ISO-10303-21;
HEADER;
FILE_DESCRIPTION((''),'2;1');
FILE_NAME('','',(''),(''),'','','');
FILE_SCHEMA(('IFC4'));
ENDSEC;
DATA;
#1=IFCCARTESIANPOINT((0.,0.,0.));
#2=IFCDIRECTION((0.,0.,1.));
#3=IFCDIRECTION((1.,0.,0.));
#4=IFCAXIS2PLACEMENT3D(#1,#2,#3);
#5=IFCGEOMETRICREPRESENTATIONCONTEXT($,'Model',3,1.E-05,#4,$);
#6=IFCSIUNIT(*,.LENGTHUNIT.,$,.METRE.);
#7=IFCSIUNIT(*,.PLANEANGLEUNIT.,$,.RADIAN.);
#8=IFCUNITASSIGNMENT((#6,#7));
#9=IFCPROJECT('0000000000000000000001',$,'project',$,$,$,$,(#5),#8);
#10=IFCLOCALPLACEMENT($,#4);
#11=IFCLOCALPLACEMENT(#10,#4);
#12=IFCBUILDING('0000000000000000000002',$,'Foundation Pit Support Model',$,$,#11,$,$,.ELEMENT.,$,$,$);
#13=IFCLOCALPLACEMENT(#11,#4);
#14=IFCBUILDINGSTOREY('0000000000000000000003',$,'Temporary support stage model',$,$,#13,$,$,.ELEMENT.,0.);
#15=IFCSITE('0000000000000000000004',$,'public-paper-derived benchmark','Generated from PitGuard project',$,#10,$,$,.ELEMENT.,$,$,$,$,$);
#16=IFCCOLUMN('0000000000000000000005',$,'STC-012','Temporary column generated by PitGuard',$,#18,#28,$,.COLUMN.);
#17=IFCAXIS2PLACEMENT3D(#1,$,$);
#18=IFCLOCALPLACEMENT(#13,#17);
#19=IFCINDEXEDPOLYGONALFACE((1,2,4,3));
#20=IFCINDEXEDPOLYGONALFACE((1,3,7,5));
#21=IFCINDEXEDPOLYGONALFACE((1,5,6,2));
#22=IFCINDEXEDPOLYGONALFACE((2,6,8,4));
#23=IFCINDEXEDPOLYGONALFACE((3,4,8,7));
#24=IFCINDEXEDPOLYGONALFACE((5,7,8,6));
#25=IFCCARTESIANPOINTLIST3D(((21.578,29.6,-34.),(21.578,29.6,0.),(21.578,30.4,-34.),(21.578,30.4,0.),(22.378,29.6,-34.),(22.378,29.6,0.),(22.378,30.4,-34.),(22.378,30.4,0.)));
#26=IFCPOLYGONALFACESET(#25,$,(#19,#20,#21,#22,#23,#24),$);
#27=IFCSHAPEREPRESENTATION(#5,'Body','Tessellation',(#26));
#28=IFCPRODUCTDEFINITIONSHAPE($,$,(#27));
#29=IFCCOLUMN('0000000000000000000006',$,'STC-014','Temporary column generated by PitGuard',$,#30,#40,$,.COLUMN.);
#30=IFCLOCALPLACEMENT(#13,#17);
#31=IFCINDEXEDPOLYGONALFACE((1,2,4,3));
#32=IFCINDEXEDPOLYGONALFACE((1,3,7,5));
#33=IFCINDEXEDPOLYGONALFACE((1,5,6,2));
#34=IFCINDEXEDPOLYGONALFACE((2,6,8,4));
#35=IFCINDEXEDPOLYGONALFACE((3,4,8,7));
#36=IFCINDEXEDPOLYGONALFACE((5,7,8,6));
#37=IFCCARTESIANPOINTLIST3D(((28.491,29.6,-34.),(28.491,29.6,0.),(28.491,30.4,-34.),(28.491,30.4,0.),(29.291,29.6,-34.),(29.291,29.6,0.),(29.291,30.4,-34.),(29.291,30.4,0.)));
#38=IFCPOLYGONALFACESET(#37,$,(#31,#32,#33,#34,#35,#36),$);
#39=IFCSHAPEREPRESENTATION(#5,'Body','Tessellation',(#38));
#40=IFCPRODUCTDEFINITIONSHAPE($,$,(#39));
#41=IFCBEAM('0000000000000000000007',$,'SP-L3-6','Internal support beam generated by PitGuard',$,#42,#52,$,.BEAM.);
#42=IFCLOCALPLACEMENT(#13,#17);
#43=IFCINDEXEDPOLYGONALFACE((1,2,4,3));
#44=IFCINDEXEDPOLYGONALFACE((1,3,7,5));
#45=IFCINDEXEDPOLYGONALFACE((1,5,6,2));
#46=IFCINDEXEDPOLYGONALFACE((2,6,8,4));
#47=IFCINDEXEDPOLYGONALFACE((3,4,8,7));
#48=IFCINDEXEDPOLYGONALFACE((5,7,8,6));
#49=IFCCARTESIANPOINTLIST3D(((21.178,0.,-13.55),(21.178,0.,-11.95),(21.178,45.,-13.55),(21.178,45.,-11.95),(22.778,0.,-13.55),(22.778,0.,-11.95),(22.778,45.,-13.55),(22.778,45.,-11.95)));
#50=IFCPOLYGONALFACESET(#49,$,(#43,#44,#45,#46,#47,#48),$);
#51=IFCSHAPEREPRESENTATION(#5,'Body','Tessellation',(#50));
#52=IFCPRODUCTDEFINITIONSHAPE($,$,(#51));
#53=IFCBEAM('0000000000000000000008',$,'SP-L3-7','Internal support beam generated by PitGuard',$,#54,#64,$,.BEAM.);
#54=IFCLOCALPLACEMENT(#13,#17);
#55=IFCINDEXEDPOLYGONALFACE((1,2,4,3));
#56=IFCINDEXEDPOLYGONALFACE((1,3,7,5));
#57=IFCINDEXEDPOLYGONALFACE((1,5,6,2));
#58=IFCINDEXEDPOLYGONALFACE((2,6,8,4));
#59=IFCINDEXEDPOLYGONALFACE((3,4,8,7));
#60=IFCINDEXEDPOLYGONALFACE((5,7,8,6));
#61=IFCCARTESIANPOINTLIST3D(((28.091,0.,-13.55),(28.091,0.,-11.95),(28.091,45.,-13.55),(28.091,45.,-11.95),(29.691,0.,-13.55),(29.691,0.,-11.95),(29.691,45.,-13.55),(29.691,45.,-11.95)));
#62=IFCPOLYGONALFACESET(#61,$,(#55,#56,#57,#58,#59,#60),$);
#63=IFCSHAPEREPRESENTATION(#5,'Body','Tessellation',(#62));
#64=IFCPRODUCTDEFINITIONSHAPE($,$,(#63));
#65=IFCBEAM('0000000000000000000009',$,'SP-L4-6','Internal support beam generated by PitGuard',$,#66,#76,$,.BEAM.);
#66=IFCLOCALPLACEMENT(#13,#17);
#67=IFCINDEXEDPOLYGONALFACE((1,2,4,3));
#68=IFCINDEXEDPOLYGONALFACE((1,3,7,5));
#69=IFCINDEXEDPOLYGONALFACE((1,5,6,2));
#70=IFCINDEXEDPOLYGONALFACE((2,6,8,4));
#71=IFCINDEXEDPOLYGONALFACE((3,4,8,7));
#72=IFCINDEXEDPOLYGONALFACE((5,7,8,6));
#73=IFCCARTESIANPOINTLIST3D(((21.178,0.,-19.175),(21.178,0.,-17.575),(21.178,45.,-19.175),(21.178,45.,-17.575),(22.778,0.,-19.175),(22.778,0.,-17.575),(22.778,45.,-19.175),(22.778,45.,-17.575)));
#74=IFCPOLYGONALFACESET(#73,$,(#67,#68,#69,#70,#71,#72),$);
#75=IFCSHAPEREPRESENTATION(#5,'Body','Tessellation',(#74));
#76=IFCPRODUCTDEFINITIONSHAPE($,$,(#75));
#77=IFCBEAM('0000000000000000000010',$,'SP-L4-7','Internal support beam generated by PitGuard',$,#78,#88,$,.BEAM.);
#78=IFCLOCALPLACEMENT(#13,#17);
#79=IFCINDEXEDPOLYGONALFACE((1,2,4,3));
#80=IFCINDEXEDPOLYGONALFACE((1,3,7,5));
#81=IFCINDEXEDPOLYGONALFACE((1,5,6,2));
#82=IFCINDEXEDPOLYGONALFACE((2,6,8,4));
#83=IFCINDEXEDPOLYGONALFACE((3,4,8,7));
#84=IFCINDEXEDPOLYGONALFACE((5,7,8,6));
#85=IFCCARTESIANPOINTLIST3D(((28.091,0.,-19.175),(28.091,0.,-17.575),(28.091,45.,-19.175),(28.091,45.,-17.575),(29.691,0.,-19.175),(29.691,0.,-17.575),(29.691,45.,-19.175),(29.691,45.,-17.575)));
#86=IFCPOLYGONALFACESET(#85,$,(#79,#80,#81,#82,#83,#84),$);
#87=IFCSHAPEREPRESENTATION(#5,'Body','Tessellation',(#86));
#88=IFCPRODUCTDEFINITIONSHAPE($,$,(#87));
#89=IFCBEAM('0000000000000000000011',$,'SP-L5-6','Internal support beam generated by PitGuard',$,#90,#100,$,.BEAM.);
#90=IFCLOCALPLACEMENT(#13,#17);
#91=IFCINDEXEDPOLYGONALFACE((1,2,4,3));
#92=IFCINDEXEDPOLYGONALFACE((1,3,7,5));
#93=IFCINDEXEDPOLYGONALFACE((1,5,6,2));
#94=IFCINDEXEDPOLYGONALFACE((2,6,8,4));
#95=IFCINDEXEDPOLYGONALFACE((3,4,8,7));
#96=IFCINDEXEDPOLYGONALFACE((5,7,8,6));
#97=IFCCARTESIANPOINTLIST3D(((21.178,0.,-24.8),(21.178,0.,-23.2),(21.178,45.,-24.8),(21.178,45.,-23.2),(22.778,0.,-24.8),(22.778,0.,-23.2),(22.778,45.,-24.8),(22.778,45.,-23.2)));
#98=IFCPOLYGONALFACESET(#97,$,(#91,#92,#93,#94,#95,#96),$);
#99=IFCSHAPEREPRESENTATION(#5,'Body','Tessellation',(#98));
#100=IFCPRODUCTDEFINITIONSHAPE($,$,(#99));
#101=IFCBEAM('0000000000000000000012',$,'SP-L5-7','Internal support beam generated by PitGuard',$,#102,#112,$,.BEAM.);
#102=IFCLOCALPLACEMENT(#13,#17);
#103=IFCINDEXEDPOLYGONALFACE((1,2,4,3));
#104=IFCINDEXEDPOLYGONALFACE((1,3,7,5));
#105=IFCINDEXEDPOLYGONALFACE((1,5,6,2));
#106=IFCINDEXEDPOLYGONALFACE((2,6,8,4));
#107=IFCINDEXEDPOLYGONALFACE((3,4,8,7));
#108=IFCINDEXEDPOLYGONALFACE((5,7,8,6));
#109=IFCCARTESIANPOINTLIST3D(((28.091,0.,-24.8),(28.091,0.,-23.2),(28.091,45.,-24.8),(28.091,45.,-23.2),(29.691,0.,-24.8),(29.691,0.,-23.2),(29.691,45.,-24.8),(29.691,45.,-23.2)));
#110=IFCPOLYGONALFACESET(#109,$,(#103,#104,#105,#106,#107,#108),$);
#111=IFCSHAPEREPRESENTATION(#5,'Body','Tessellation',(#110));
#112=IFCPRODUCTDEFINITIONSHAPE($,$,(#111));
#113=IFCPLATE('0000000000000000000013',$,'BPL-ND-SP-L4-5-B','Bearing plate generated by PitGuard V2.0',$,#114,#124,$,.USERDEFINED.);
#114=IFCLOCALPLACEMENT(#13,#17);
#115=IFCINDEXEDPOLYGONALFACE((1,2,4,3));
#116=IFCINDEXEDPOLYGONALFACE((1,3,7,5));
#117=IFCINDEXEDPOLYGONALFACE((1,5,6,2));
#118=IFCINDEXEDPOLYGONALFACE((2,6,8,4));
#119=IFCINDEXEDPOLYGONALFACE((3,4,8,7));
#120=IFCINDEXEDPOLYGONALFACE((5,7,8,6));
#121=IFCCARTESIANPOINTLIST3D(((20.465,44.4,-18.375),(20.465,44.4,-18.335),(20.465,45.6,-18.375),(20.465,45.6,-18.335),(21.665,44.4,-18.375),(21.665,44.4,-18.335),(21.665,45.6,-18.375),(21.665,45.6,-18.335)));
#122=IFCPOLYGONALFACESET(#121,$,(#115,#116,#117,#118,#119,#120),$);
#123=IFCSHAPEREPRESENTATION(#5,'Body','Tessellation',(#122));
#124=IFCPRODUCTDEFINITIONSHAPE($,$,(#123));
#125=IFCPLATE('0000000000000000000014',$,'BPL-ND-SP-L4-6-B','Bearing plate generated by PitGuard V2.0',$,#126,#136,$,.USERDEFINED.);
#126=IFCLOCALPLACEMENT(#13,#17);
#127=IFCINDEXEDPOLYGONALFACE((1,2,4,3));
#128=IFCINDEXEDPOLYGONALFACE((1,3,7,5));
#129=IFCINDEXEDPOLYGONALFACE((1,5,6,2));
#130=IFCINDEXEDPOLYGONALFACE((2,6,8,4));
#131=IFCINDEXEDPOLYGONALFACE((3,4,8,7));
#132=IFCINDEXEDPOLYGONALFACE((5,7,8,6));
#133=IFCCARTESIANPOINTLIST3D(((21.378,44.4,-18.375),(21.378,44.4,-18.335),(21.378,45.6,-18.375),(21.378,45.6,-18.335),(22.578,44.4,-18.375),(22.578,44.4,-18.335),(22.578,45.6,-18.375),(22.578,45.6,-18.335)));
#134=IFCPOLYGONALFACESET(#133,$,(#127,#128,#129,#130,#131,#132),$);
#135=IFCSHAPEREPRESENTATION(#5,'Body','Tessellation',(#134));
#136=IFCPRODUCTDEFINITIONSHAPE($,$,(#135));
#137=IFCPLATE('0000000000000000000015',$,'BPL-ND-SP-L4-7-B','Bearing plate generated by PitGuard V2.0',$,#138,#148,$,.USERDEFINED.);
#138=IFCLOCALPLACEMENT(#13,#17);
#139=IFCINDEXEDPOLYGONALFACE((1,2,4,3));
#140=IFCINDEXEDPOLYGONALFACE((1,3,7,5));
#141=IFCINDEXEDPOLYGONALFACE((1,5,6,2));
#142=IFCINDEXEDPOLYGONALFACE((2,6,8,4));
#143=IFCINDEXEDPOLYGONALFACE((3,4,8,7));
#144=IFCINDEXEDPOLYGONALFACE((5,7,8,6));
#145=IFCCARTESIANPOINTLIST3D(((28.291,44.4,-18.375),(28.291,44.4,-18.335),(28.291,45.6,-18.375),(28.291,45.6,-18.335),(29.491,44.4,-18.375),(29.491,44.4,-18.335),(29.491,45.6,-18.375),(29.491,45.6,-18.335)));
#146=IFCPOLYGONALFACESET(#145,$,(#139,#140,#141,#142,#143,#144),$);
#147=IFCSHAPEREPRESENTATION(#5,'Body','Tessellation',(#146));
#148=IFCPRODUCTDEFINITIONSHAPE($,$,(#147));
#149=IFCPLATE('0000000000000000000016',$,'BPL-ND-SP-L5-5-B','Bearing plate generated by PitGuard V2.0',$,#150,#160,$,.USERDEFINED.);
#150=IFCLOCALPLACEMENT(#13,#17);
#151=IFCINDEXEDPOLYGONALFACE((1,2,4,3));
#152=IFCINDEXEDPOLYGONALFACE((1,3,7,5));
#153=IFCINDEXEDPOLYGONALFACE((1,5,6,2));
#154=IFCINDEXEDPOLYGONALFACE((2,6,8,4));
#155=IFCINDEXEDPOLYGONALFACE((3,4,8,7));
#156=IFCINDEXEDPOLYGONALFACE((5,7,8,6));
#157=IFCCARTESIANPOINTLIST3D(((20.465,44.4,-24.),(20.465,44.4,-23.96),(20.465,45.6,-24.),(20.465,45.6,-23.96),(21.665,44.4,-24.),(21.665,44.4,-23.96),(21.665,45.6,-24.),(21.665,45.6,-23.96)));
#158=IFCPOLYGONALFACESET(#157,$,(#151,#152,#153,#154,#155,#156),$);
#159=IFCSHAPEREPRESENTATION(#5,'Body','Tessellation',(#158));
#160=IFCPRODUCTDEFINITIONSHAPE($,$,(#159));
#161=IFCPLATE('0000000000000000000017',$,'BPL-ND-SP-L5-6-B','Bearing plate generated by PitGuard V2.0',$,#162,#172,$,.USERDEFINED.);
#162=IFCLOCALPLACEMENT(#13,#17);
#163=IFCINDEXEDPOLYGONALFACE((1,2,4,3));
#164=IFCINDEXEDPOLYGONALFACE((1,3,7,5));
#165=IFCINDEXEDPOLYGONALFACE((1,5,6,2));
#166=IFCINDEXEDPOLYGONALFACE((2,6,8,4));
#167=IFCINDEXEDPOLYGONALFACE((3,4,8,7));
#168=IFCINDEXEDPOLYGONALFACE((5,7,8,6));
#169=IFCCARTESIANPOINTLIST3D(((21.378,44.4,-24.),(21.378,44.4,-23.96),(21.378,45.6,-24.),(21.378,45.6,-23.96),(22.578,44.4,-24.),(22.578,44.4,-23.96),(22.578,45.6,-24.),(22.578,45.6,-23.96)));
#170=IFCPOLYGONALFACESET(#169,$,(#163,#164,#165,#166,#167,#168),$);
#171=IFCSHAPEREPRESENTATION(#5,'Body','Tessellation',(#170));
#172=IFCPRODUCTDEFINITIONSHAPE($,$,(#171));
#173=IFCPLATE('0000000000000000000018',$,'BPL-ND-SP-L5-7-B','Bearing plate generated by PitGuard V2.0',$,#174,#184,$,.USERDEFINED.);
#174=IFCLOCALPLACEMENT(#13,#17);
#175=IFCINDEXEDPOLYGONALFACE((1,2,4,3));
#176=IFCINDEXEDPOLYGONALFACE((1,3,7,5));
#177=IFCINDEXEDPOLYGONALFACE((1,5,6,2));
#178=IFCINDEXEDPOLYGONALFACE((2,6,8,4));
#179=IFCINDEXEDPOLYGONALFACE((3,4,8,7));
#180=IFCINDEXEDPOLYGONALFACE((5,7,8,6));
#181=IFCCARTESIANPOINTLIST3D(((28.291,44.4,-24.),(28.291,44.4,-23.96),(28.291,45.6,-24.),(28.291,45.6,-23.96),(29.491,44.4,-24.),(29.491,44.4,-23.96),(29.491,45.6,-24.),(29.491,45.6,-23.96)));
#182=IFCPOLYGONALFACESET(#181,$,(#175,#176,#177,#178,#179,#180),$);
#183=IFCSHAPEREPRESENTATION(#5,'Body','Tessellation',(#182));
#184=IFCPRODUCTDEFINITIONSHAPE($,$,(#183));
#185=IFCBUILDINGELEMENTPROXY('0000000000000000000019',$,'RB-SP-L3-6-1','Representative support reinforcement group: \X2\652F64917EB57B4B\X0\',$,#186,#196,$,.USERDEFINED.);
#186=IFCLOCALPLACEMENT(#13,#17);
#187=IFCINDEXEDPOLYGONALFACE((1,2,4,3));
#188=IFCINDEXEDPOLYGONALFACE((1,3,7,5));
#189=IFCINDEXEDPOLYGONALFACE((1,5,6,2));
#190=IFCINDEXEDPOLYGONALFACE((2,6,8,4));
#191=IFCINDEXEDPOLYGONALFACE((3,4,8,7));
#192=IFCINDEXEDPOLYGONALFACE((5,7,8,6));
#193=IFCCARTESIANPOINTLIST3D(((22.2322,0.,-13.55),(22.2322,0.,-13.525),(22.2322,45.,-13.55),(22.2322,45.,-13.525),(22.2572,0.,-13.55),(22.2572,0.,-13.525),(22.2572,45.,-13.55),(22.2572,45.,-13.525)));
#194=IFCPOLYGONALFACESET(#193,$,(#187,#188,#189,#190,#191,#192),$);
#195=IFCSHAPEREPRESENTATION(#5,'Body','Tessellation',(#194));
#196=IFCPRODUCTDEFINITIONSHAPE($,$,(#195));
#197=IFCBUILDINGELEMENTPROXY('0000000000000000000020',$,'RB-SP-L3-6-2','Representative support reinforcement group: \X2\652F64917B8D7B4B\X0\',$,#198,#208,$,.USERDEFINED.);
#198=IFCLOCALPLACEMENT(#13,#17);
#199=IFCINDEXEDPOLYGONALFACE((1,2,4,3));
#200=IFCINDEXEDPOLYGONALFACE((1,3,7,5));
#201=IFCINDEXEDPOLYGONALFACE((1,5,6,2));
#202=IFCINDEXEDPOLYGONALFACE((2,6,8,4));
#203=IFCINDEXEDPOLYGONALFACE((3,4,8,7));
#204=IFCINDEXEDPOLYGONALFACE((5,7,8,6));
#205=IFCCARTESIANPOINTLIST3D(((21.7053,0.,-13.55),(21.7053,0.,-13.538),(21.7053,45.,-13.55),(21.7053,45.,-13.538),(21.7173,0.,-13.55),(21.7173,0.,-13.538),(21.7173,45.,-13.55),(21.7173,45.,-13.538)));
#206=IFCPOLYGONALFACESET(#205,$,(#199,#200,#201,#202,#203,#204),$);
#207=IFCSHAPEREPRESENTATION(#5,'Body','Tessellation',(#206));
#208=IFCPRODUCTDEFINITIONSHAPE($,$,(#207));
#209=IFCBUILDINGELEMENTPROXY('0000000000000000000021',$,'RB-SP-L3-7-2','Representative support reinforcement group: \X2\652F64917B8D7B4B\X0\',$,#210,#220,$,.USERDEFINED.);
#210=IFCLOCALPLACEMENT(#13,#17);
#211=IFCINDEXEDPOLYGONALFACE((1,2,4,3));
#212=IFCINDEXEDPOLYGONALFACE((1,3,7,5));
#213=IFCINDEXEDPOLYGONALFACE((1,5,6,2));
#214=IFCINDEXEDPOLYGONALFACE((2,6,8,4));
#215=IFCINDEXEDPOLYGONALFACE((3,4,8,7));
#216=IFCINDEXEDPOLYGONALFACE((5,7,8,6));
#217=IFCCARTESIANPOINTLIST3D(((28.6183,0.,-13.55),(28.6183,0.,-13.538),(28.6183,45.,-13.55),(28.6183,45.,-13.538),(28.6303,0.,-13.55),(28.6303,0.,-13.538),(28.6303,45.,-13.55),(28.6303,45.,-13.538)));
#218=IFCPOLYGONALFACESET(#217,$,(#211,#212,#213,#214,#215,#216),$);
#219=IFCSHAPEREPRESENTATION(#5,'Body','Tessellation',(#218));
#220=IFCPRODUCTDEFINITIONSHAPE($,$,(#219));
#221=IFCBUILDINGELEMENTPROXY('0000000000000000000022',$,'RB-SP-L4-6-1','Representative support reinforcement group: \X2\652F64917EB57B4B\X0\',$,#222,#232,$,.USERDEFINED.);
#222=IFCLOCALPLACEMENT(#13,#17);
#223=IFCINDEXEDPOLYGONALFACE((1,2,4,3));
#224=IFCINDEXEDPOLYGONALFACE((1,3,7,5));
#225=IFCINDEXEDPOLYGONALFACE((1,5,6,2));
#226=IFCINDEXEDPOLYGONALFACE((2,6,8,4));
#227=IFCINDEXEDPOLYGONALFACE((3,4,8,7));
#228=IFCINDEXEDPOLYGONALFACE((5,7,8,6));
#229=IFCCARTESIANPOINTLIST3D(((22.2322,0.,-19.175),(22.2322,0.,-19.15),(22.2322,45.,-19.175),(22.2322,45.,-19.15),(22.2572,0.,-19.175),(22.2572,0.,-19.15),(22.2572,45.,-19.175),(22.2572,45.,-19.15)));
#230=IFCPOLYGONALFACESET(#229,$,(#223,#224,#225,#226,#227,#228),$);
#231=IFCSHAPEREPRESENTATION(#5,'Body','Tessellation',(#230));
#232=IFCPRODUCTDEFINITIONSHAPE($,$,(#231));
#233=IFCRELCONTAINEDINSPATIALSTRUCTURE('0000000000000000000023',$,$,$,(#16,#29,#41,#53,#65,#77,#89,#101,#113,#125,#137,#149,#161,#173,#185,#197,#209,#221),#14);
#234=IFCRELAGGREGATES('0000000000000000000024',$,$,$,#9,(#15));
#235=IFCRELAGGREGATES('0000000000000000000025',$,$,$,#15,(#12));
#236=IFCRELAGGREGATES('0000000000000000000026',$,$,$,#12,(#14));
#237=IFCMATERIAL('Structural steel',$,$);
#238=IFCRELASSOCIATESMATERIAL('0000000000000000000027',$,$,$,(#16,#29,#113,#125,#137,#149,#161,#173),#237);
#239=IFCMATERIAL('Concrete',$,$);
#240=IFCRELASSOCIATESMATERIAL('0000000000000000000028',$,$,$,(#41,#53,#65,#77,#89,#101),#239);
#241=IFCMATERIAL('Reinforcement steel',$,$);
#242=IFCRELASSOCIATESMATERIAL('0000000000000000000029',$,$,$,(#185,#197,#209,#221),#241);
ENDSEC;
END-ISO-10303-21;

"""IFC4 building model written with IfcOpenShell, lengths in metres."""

from ifc_helpers import new_model, si_unit, frame, origin_with_axes, origin_2d, place, context, project, spatial, rectangle, extrude, material, element, save


model = new_model("IFC4")

# Units and contexts
model_context = context("Model", 3, precision=1e-05, world=origin_with_axes())
ifc_project = project(units=[si_unit("LENGTHUNIT", "METRE"), si_unit("PLANEANGLEUNIT", "RADIAN")], contexts=[model_context])

# Site, building, storey
site_placement = place(None, origin_with_axes())
site = spatial("IfcSite", under=ifc_project, at=site_placement, Name="public-paper-derived benchmark", Description="Generated from PitGuard project", CompositionType="ELEMENT")
building_placement = place(site_placement, origin_with_axes())
building = spatial("IfcBuilding", under=site, at=building_placement, Name="Foundation Pit Support Model", CompositionType="ELEMENT")
storey_placement = place(building_placement, origin_with_axes())
storey = spatial("IfcBuildingStorey", under=building, at=storey_placement, Name="Temporary support stage model", CompositionType="ELEMENT", Elevation=0.0)

# Columns
ifc_material_1 = material(Name="Structural steel")
for number, where, z_axis, x_axis, name in (
    (1, (21.978, 30.0, -34.0), (0.0, 0.0, 1.0), (1.0, 0.0, 0.0), "STC-012"),
    (2, (28.891, 30.0, -34.0), (0.0, 0.0, 1.0), (1.0, 0.0, 0.0), "STC-014"),
):
    element("IfcColumn", number, at=place(storey_placement, frame(where, z_axis=z_axis, x_axis=x_axis)), inside=storey, material=ifc_material_1, Name=name, Description="Temporary column generated by PitGuard", PredefinedType="COLUMN", context=model_context, shape_type="SweptSolid", body=[
        extrude(rectangle(XDim=0.8, YDim=0.8, at=origin_2d()), origin_with_axes(), (0.0, 0.0, 1.0), 34.0),
    ])

# Beams
ifc_material_2 = material(Name="Concrete")
for number, where, z_axis, x_axis, name in (
    (3, (21.978, 22.5, -13.55), (0.0, 0.0, 1.0), (0.0, 1.0, 0.0), "SP-L3-6"),
    (4, (28.891, 22.5, -13.55), (0.0, 0.0, 1.0), (0.0, 1.0, 0.0), "SP-L3-7"),
    (5, (21.978, 22.5, -19.175), (0.0, 0.0, 1.0), (0.0, 1.0, 0.0), "SP-L4-6"),
    (6, (28.891, 22.5, -19.175), (0.0, 0.0, 1.0), (0.0, 1.0, 0.0), "SP-L4-7"),
    (7, (21.978, 22.5, -24.8), (0.0, 0.0, 1.0), (0.0, 1.0, 0.0), "SP-L5-6"),
    (8, (28.891, 22.5, -24.8), (0.0, 0.0, 1.0), (0.0, 1.0, 0.0), "SP-L5-7"),
):
    element("IfcBeam", number, at=place(storey_placement, frame(where, z_axis=z_axis, x_axis=x_axis)), inside=storey, material=ifc_material_2, Name=name, Description="Internal support beam generated by PitGuard", PredefinedType="BEAM", context=model_context, shape_type="SweptSolid", body=[
        extrude(rectangle(XDim=45.0, YDim=1.6, at=origin_2d()), origin_with_axes(), (0.0, 0.0, 1.0), 1.6),
    ])

# Plates
for number, where, z_axis, x_axis, name in (
    (9, (21.065, 45.0, -18.375), (0.0, 0.0, 1.0), (1.0, 0.0, 0.0), "BPL-ND-SP-L4-5-B"),
    (10, (21.978, 45.0, -18.375), (0.0, 0.0, 1.0), (1.0, 0.0, 0.0), "BPL-ND-SP-L4-6-B"),
    (11, (28.891, 45.0, -18.375), (0.0, 0.0, 1.0), (1.0, 0.0, 0.0), "BPL-ND-SP-L4-7-B"),
    (12, (21.065, 45.0, -24.0), (0.0, 0.0, 1.0), (1.0, 0.0, 0.0), "BPL-ND-SP-L5-5-B"),
    (13, (21.978, 45.0, -24.0), (0.0, 0.0, 1.0), (1.0, 0.0, 0.0), "BPL-ND-SP-L5-6-B"),
    (14, (28.891, 45.0, -24.0), (0.0, 0.0, 1.0), (1.0, 0.0, 0.0), "BPL-ND-SP-L5-7-B"),
):
    element("IfcPlate", number, at=place(storey_placement, frame(where, z_axis=z_axis, x_axis=x_axis)), inside=storey, material=ifc_material_1, Name=name, Description="Bearing plate generated by PitGuard V2.0", PredefinedType="USERDEFINED", context=model_context, shape_type="SweptSolid", body=[
        extrude(rectangle(XDim=1.2, YDim=1.2, at=origin_2d()), origin_with_axes(), (0.0, 0.0, 1.0), 0.04),
    ])

# Building element proxies
ifc_material_3 = material(Name="Reinforcement steel")
proxy_1_placement = place(storey_placement, frame((22.2447, 22.5, -13.55), z_axis=(0.0, 0.0, 1.0), x_axis=(0.0, 1.0, 0.0)))
element("IfcBuildingElementProxy", 15, at=proxy_1_placement, inside=storey, material=ifc_material_3, Name="RB-SP-L3-6-1", Description="Representative support reinforcement group: 支撑纵筋", PredefinedType="USERDEFINED", context=model_context, shape_type="SweptSolid", body=[
    extrude(rectangle(XDim=45.0, YDim=0.025, at=origin_2d()), origin_with_axes(), (0.0, 0.0, 1.0), 0.025),
])
for number, where, z_axis, x_axis, name in (
    (16, (21.7113, 22.5, -13.55), (0.0, 0.0, 1.0), (0.0, 1.0, 0.0), "RB-SP-L3-6-2"),
    (17, (28.6243, 22.5, -13.55), (0.0, 0.0, 1.0), (0.0, 1.0, 0.0), "RB-SP-L3-7-2"),
):
    element("IfcBuildingElementProxy", number, at=place(storey_placement, frame(where, z_axis=z_axis, x_axis=x_axis)), inside=storey, material=ifc_material_3, Name=name, Description="Representative support reinforcement group: 支撑箍筋", PredefinedType="USERDEFINED", context=model_context, shape_type="SweptSolid", body=[
        extrude(rectangle(XDim=45.0, YDim=0.012, at=origin_2d()), origin_with_axes(), (0.0, 0.0, 1.0), 0.012),
    ])
proxy_2_placement = place(storey_placement, frame((22.2447, 22.5, -19.175), z_axis=(0.0, 0.0, 1.0), x_axis=(0.0, 1.0, 0.0)))
element("IfcBuildingElementProxy", 18, at=proxy_2_placement, inside=storey, material=ifc_material_3, Name="RB-SP-L4-6-1", Description="Representative support reinforcement group: 支撑纵筋", PredefinedType="USERDEFINED", context=model_context, shape_type="SweptSolid", body=[
    extrude(rectangle(XDim=45.0, YDim=0.025, at=origin_2d()), origin_with_axes(), (0.0, 0.0, 1.0), 0.025),
])

save(model, "model.ifc")
